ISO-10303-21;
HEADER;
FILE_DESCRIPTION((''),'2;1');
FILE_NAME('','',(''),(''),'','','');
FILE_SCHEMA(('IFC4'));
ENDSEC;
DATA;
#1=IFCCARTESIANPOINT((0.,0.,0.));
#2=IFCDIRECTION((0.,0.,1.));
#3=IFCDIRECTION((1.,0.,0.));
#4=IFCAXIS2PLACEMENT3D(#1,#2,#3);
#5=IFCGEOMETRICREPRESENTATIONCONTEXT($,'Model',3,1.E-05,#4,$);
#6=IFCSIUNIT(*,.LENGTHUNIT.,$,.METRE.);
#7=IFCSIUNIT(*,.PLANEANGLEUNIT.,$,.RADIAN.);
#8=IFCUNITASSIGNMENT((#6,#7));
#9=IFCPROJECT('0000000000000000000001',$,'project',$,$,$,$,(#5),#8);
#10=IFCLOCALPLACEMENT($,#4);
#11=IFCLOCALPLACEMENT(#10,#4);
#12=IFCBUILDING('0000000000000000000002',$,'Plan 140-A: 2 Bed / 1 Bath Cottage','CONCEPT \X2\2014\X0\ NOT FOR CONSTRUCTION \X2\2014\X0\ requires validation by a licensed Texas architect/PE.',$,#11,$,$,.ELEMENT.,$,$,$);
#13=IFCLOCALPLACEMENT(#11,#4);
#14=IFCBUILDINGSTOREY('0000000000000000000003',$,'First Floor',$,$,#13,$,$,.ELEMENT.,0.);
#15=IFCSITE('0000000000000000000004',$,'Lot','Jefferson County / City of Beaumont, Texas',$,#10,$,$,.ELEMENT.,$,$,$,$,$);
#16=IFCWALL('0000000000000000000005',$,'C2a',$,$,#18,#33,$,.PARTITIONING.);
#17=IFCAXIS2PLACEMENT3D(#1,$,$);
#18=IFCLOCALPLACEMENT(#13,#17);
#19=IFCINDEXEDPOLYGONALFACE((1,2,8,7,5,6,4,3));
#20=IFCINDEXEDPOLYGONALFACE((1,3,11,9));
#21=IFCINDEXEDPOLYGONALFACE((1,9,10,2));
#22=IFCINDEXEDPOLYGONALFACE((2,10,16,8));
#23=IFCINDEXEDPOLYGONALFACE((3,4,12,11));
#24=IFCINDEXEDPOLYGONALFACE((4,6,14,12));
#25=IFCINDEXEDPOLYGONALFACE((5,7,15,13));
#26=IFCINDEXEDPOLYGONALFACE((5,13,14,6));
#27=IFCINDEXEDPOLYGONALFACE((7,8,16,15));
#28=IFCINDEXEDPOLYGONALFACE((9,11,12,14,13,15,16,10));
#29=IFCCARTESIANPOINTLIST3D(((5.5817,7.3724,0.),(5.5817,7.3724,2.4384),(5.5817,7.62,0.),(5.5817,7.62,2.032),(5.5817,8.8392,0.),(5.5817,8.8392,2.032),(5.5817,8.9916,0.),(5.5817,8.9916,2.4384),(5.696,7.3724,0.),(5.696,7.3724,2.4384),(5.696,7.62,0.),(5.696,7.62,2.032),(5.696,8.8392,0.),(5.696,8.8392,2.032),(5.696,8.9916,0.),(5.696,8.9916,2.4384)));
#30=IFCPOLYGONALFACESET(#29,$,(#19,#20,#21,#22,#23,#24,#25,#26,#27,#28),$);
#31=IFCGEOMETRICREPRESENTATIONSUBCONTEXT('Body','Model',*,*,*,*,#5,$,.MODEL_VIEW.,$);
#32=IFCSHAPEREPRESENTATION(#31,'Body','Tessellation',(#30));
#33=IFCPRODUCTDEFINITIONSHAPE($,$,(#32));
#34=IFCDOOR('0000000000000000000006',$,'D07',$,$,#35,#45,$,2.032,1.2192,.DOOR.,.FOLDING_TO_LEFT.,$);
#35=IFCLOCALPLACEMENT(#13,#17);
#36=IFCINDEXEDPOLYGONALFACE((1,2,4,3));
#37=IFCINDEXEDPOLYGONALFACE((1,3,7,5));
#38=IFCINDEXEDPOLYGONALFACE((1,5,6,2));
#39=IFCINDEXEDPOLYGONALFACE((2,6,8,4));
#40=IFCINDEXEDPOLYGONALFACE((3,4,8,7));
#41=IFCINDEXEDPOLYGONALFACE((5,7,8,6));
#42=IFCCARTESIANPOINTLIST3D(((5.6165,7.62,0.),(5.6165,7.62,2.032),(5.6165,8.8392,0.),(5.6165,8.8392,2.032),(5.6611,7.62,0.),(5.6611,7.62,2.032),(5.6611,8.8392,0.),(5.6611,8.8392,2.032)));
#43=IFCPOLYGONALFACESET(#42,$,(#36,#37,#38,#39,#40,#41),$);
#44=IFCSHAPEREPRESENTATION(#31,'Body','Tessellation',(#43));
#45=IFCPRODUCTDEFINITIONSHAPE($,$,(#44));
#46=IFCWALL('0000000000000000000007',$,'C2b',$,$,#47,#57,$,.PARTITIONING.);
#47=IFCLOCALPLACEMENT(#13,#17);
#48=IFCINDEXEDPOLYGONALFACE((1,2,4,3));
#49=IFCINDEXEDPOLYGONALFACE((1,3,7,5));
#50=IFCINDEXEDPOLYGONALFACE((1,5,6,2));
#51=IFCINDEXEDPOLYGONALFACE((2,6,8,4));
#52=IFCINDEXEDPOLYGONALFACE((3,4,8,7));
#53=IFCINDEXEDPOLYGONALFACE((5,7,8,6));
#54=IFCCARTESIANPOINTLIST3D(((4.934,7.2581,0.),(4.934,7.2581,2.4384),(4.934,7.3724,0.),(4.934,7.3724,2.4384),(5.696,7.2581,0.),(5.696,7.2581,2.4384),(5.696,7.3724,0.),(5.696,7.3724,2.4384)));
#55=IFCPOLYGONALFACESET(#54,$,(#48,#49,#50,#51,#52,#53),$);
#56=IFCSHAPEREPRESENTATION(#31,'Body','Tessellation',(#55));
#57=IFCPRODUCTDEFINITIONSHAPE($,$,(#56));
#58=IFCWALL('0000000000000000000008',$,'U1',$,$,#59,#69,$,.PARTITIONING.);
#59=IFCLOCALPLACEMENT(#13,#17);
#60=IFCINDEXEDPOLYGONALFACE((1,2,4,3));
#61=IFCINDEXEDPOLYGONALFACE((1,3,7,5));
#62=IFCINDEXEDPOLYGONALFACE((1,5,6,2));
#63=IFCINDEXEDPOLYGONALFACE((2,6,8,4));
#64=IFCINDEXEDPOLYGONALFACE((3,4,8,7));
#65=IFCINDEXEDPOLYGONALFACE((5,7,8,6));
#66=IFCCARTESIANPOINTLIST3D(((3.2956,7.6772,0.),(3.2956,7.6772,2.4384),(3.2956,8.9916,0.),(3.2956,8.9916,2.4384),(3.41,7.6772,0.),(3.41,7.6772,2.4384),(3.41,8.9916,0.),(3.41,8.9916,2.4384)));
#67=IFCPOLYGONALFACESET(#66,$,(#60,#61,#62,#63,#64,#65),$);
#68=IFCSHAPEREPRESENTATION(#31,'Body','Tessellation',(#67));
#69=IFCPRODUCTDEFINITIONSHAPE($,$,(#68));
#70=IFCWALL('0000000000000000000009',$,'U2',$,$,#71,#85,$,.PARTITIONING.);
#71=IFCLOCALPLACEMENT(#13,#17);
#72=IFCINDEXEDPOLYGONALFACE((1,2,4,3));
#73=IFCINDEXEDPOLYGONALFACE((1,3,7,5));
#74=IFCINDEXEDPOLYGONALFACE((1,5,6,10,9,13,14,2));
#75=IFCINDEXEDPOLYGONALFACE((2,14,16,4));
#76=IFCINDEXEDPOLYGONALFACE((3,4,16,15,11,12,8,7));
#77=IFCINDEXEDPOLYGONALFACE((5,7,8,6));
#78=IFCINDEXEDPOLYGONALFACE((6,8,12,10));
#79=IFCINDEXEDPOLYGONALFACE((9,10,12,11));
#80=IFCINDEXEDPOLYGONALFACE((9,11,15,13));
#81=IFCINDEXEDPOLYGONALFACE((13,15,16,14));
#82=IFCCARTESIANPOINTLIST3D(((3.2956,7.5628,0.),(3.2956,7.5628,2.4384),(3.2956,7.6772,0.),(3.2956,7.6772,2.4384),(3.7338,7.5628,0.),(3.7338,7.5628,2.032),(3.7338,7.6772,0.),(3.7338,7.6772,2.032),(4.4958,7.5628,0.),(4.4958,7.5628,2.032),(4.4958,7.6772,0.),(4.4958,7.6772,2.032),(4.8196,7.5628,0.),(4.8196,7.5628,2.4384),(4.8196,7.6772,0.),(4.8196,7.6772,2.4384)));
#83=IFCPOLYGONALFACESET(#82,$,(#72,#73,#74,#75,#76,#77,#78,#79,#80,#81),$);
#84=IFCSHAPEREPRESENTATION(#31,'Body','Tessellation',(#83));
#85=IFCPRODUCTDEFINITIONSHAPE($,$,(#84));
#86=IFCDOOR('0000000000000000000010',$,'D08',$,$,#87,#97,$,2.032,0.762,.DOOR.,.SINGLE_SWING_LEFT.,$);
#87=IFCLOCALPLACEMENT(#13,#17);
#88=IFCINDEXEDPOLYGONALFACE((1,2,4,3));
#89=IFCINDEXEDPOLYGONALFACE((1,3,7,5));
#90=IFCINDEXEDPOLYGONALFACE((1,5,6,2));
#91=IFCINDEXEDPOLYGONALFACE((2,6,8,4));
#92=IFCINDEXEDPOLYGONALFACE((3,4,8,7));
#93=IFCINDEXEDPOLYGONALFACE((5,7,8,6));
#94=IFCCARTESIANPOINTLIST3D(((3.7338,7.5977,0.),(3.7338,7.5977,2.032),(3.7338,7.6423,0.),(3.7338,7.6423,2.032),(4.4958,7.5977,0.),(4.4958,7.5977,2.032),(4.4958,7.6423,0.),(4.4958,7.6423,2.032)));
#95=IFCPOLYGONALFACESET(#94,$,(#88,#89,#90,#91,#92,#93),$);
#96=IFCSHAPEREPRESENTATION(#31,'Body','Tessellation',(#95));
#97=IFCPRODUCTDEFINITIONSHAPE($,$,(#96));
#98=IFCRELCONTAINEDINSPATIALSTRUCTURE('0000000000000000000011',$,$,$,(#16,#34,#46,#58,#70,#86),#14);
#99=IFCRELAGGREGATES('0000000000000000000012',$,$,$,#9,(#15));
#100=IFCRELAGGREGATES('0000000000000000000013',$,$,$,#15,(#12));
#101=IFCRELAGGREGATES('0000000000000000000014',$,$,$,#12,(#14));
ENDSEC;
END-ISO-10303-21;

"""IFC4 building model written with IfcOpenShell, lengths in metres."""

from ifc_helpers import new_model, si_unit, frame, frame_2d, origin_with_axes, place, context, subcontext, project, spatial, rectangle, extrude, element, fill, save


model = new_model("IFC4")

# Units and contexts
model_context = context("Model", 3, precision=1e-05, world=origin_with_axes())
body_context = subcontext(model_context, "Body", "Model", "MODEL_VIEW")
ifc_project = project(units=[si_unit("LENGTHUNIT", "METRE"), si_unit("PLANEANGLEUNIT", "RADIAN")], contexts=[model_context])

# Site, building, storey
site_placement = place(None, origin_with_axes())
site = spatial("IfcSite", under=ifc_project, at=site_placement, Name="Lot", Description="Jefferson County / City of Beaumont, Texas", CompositionType="ELEMENT")
building_placement = place(site_placement, origin_with_axes())
building = spatial("IfcBuilding", under=site, at=building_placement, Name="Plan 140-A: 2 Bed / 1 Bath Cottage", Description="CONCEPT — NOT FOR CONSTRUCTION — requires validation by a licensed Texas architect/PE.", CompositionType="ELEMENT")
storey_placement = place(building_placement, origin_with_axes())
storey = spatial("IfcBuildingStorey", under=building, at=storey_placement, Name="First Floor", CompositionType="ELEMENT", Elevation=0.0)

# Wall, opening, door
wall_1_placement = place(storey_placement, frame((5.6388, 7.3723, 0.0), z_axis=(0.0, 0.0, 1.0), x_axis=(0.0, 1.0, 0.0)))
wall_1 = element("IfcWall", 1, at=wall_1_placement, inside=storey, Name="C2a", PredefinedType="PARTITIONING", context=body_context, shape_type="SweptSolid", body=[
    extrude(rectangle(XDim=1.6193, YDim=0.1143, at=frame_2d((0.8096, 0.0), x_axis=(1.0, 0.0))), origin_with_axes(), (0.0, 0.0, 1.0), 2.4384),
])
opening_1_placement = place(wall_1_placement, frame((0.2477, 0.0, 0.0), z_axis=(0.0, 0.0, 1.0), x_axis=(1.0, 0.0, 0.0)))
opening_1 = element("IfcOpeningElement", 2, at=opening_1_placement, cuts=wall_1, PredefinedType="OPENING", context=body_context, shape_type="SweptSolid", body=[
    extrude(rectangle(XDim=1.2192, YDim=0.1448, at=frame_2d((0.6096, 0.0), x_axis=(1.0, 0.0))), origin_with_axes(), (0.0, 0.0, 1.0), 2.032),
])
door_1_placement = place(opening_1_placement, origin_with_axes())
door_1 = element("IfcDoor", 3, at=door_1_placement, inside=storey, Name="D07", OperationType="FOLDING_TO_LEFT", OverallHeight=2.032, OverallWidth=1.2192, PredefinedType="DOOR", context=body_context, shape_type="SweptSolid", body=[
    extrude(rectangle(XDim=1.2192, YDim=0.0445, at=frame_2d((0.6096, 0.0), x_axis=(1.0, 0.0))), origin_with_axes(), (0.0, 0.0, 1.0), 2.032),
])
fill(opening_1, door_1)

# Walls
wall_2_placement = place(storey_placement, frame((4.934, 7.3152, 0.0), z_axis=(0.0, 0.0, 1.0), x_axis=(1.0, 0.0, 0.0)))
element("IfcWall", 4, at=wall_2_placement, inside=storey, Name="C2b", PredefinedType="PARTITIONING", context=body_context, shape_type="SweptSolid", body=[
    extrude(rectangle(XDim=0.762, YDim=0.1143, at=frame_2d((0.381, 0.0), x_axis=(1.0, 0.0))), origin_with_axes(), (0.0, 0.0, 1.0), 2.4384),
])
wall_3_placement = place(storey_placement, frame((3.3528, 7.6772, 0.0), z_axis=(0.0, 0.0, 1.0), x_axis=(0.0, 1.0, 0.0)))
element("IfcWall", 5, at=wall_3_placement, inside=storey, Name="U1", PredefinedType="PARTITIONING", context=body_context, shape_type="SweptSolid", body=[
    extrude(rectangle(XDim=1.3145, YDim=0.1143, at=frame_2d((0.6572, 0.0), x_axis=(1.0, 0.0))), origin_with_axes(), (0.0, 0.0, 1.0), 2.4384),
])

# Wall, opening, door
wall_4_placement = place(storey_placement, frame((3.2957, 7.62, 0.0), z_axis=(0.0, 0.0, 1.0), x_axis=(1.0, 0.0, 0.0)))
wall_4 = element("IfcWall", 6, at=wall_4_placement, inside=storey, Name="U2", PredefinedType="PARTITIONING", context=body_context, shape_type="SweptSolid", body=[
    extrude(rectangle(XDim=1.524, YDim=0.1143, at=frame_2d((0.762, 0.0), x_axis=(1.0, 0.0))), origin_with_axes(), (0.0, 0.0, 1.0), 2.4384),
])
opening_2_placement = place(wall_4_placement, frame((0.4382, 0.0, 0.0), z_axis=(0.0, 0.0, 1.0), x_axis=(1.0, 0.0, 0.0)))
opening_2 = element("IfcOpeningElement", 7, at=opening_2_placement, cuts=wall_4, PredefinedType="OPENING", context=body_context, shape_type="SweptSolid", body=[
    extrude(rectangle(XDim=0.762, YDim=0.1448, at=frame_2d((0.381, 0.0), x_axis=(1.0, 0.0))), origin_with_axes(), (0.0, 0.0, 1.0), 2.032),
])
door_2_placement = place(opening_2_placement, origin_with_axes())
door_2 = element("IfcDoor", 8, at=door_2_placement, inside=storey, Name="D08", OperationType="SINGLE_SWING_LEFT", OverallHeight=2.032, OverallWidth=0.762, PredefinedType="DOOR", context=body_context, shape_type="SweptSolid", body=[
    extrude(rectangle(XDim=0.762, YDim=0.0445, at=frame_2d((0.381, 0.0), x_axis=(1.0, 0.0))), origin_with_axes(), (0.0, 0.0, 1.0), 2.032),
])
fill(opening_2, door_2)

save(model, "model.ifc")
